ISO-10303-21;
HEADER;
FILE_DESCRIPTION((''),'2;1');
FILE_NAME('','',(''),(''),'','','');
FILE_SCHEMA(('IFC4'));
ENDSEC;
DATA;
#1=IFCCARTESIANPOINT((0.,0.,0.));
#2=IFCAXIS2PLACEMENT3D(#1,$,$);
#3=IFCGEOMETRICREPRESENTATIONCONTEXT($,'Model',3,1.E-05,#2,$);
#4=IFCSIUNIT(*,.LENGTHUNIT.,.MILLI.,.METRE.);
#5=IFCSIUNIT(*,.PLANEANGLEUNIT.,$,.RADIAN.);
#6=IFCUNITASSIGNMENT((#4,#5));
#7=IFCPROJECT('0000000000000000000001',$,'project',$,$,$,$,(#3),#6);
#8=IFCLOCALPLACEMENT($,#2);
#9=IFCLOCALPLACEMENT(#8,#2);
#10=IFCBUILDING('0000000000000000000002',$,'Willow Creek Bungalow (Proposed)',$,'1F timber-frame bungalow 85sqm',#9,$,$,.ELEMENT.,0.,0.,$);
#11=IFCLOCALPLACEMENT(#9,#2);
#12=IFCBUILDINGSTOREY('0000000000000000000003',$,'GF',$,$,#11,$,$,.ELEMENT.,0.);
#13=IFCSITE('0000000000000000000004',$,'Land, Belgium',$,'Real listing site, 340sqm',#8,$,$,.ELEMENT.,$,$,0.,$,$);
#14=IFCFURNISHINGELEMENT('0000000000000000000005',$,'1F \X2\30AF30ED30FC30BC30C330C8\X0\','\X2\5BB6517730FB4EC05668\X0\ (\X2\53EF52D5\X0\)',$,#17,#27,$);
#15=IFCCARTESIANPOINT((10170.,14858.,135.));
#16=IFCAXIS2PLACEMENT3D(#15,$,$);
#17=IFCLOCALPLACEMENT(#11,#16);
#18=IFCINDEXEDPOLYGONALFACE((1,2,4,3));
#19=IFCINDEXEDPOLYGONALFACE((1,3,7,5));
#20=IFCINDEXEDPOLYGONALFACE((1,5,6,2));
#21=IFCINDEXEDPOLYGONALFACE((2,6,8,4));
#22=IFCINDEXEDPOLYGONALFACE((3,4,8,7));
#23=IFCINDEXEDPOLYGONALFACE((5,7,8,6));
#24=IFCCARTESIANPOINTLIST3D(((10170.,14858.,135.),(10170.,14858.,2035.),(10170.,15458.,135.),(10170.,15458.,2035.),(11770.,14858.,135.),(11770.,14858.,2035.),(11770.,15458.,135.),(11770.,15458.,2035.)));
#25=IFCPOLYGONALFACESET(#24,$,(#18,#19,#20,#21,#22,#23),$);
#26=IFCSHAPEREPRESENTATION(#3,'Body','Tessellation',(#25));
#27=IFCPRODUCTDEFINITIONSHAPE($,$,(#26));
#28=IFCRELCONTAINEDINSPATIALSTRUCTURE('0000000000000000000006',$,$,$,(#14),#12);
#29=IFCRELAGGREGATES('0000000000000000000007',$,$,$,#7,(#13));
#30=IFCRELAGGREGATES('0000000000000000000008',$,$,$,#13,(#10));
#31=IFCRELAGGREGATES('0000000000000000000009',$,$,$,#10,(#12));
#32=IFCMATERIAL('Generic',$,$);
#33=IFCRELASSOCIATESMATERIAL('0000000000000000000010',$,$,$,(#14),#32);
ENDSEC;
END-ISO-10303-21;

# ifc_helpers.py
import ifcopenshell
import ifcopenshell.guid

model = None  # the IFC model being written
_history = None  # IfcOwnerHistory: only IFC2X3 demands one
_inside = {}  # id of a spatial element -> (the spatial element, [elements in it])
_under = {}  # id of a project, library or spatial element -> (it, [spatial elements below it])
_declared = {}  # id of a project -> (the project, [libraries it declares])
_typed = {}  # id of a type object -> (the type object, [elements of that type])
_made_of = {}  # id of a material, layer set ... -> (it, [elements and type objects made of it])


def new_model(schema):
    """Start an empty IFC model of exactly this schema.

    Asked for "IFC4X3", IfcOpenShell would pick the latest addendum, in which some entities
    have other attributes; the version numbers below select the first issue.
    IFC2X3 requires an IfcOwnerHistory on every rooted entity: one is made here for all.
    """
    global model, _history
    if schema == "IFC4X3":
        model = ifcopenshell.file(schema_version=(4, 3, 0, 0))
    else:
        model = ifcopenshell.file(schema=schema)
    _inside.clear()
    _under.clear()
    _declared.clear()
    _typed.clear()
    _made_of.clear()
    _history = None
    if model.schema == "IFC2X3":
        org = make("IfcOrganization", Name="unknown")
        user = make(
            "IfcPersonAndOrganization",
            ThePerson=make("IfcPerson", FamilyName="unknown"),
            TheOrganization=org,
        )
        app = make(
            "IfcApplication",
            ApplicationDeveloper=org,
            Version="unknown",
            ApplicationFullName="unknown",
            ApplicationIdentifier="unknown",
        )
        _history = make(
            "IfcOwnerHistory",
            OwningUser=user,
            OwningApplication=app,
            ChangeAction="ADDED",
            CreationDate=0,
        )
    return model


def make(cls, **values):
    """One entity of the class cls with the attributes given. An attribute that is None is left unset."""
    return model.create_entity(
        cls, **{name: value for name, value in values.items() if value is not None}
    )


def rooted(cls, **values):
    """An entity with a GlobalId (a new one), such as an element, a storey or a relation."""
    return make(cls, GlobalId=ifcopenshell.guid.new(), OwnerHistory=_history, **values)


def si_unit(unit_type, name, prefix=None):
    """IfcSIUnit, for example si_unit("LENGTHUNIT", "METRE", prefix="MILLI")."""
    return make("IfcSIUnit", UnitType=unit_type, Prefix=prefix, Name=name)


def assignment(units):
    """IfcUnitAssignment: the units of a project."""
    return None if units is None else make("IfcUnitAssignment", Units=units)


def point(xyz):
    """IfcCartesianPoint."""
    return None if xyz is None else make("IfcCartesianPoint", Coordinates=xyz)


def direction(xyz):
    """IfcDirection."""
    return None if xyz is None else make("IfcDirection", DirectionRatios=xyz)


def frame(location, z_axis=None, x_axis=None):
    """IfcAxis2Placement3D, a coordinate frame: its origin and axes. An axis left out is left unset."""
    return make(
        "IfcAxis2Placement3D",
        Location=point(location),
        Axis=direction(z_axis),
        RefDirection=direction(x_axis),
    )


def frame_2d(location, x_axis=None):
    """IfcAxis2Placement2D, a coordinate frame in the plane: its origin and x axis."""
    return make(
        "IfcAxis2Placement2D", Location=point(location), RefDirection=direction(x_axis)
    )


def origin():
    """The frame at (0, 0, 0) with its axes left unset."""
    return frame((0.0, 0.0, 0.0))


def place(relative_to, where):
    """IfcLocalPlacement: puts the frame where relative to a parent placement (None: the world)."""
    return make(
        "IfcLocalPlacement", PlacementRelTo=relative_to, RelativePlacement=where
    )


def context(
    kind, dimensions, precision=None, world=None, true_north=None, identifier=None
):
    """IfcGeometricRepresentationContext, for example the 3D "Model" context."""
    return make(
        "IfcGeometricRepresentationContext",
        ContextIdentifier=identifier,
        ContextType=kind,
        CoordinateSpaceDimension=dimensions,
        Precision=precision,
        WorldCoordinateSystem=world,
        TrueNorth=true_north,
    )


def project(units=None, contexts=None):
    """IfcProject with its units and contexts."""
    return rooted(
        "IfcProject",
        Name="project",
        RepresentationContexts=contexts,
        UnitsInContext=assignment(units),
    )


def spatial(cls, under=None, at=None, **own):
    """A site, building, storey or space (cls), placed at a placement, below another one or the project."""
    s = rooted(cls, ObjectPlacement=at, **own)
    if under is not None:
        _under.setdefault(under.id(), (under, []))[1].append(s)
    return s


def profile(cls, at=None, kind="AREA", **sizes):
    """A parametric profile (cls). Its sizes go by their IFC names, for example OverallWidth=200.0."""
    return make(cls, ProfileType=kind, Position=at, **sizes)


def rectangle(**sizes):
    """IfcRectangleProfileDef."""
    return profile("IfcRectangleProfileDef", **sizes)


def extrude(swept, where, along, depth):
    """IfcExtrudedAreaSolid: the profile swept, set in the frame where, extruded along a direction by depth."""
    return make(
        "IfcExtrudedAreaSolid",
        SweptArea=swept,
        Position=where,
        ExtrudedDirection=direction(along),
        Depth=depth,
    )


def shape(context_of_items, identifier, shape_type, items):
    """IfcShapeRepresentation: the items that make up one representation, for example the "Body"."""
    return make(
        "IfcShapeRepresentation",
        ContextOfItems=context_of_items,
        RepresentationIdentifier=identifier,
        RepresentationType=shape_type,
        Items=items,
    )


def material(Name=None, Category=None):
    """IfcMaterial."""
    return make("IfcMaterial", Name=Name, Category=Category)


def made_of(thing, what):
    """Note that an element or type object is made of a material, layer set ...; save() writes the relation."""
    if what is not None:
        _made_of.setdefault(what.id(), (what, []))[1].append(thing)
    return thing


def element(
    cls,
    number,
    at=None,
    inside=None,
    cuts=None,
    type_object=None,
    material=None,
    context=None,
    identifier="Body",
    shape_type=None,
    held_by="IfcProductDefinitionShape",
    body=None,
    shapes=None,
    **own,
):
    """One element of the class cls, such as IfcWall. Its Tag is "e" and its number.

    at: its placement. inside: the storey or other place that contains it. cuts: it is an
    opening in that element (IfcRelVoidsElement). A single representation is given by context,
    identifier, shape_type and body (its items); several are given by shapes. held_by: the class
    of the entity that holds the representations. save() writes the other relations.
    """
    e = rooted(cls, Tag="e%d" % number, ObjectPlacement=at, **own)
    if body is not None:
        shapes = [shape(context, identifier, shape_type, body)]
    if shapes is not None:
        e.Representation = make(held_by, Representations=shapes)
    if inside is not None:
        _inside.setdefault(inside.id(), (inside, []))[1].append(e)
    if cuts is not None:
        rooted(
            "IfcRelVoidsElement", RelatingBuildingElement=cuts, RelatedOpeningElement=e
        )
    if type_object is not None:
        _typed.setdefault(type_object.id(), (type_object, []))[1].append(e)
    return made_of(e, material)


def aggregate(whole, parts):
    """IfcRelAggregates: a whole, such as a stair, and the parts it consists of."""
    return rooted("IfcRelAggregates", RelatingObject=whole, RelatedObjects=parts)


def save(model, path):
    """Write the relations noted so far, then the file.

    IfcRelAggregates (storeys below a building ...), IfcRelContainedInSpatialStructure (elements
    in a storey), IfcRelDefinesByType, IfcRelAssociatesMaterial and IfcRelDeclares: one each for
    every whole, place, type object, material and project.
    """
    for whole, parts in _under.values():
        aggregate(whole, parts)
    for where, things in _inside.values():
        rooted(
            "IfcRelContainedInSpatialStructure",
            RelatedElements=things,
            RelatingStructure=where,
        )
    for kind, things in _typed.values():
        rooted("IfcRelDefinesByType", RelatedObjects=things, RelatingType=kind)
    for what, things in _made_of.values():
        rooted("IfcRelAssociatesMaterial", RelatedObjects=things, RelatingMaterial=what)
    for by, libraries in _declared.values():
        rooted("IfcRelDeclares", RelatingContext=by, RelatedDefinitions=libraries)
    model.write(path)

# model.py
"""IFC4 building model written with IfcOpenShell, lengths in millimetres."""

from ifc_helpers import new_model, si_unit, frame, frame_2d, origin, place, context, project, spatial, rectangle, extrude, material, element, save


model = new_model("IFC4")

# Units and contexts
model_context = context("Model", 3, precision=1e-05, world=origin())
ifc_project = project(units=[si_unit("LENGTHUNIT", "METRE", prefix="MILLI"), si_unit("PLANEANGLEUNIT", "RADIAN")], contexts=[model_context])

# Site, building, storey
site_placement = place(None, origin())
site = spatial("IfcSite", under=ifc_project, at=site_placement, Name="Land, Belgium", ObjectType="Real listing site, 340sqm", CompositionType="ELEMENT", RefElevation=0.0)
building_placement = place(site_placement, origin())
building = spatial("IfcBuilding", under=site, at=building_placement, Name="Willow Creek Bungalow (Proposed)", ObjectType="1F timber-frame bungalow 85sqm", CompositionType="ELEMENT", ElevationOfRefHeight=0.0, ElevationOfTerrain=0.0)
storey_placement = place(building_placement, origin())
storey = spatial("IfcBuildingStorey", under=building, at=storey_placement, Name="GF", CompositionType="ELEMENT", Elevation=0.0)

# Shared definitions
ifc_material_1 = material(Name="Generic")

# Furnishing element
furnishing_placement = place(storey_placement, frame((10170.0, 14858.0, 135.0)))
element("IfcFurnishingElement", 1, at=furnishing_placement, inside=storey, material=ifc_material_1, Name="1F クローゼット", Description="家具・什器 (可動)", context=model_context, shape_type="SweptSolid", body=[
    extrude(rectangle(XDim=1600.0, YDim=600.0, at=frame_2d((800.0, 300.0))), frame((10170.0, 14858.0, 135.0)), (0.0, 0.0, 1.0), 1900.0),
])

save(model, "model.ifc")
